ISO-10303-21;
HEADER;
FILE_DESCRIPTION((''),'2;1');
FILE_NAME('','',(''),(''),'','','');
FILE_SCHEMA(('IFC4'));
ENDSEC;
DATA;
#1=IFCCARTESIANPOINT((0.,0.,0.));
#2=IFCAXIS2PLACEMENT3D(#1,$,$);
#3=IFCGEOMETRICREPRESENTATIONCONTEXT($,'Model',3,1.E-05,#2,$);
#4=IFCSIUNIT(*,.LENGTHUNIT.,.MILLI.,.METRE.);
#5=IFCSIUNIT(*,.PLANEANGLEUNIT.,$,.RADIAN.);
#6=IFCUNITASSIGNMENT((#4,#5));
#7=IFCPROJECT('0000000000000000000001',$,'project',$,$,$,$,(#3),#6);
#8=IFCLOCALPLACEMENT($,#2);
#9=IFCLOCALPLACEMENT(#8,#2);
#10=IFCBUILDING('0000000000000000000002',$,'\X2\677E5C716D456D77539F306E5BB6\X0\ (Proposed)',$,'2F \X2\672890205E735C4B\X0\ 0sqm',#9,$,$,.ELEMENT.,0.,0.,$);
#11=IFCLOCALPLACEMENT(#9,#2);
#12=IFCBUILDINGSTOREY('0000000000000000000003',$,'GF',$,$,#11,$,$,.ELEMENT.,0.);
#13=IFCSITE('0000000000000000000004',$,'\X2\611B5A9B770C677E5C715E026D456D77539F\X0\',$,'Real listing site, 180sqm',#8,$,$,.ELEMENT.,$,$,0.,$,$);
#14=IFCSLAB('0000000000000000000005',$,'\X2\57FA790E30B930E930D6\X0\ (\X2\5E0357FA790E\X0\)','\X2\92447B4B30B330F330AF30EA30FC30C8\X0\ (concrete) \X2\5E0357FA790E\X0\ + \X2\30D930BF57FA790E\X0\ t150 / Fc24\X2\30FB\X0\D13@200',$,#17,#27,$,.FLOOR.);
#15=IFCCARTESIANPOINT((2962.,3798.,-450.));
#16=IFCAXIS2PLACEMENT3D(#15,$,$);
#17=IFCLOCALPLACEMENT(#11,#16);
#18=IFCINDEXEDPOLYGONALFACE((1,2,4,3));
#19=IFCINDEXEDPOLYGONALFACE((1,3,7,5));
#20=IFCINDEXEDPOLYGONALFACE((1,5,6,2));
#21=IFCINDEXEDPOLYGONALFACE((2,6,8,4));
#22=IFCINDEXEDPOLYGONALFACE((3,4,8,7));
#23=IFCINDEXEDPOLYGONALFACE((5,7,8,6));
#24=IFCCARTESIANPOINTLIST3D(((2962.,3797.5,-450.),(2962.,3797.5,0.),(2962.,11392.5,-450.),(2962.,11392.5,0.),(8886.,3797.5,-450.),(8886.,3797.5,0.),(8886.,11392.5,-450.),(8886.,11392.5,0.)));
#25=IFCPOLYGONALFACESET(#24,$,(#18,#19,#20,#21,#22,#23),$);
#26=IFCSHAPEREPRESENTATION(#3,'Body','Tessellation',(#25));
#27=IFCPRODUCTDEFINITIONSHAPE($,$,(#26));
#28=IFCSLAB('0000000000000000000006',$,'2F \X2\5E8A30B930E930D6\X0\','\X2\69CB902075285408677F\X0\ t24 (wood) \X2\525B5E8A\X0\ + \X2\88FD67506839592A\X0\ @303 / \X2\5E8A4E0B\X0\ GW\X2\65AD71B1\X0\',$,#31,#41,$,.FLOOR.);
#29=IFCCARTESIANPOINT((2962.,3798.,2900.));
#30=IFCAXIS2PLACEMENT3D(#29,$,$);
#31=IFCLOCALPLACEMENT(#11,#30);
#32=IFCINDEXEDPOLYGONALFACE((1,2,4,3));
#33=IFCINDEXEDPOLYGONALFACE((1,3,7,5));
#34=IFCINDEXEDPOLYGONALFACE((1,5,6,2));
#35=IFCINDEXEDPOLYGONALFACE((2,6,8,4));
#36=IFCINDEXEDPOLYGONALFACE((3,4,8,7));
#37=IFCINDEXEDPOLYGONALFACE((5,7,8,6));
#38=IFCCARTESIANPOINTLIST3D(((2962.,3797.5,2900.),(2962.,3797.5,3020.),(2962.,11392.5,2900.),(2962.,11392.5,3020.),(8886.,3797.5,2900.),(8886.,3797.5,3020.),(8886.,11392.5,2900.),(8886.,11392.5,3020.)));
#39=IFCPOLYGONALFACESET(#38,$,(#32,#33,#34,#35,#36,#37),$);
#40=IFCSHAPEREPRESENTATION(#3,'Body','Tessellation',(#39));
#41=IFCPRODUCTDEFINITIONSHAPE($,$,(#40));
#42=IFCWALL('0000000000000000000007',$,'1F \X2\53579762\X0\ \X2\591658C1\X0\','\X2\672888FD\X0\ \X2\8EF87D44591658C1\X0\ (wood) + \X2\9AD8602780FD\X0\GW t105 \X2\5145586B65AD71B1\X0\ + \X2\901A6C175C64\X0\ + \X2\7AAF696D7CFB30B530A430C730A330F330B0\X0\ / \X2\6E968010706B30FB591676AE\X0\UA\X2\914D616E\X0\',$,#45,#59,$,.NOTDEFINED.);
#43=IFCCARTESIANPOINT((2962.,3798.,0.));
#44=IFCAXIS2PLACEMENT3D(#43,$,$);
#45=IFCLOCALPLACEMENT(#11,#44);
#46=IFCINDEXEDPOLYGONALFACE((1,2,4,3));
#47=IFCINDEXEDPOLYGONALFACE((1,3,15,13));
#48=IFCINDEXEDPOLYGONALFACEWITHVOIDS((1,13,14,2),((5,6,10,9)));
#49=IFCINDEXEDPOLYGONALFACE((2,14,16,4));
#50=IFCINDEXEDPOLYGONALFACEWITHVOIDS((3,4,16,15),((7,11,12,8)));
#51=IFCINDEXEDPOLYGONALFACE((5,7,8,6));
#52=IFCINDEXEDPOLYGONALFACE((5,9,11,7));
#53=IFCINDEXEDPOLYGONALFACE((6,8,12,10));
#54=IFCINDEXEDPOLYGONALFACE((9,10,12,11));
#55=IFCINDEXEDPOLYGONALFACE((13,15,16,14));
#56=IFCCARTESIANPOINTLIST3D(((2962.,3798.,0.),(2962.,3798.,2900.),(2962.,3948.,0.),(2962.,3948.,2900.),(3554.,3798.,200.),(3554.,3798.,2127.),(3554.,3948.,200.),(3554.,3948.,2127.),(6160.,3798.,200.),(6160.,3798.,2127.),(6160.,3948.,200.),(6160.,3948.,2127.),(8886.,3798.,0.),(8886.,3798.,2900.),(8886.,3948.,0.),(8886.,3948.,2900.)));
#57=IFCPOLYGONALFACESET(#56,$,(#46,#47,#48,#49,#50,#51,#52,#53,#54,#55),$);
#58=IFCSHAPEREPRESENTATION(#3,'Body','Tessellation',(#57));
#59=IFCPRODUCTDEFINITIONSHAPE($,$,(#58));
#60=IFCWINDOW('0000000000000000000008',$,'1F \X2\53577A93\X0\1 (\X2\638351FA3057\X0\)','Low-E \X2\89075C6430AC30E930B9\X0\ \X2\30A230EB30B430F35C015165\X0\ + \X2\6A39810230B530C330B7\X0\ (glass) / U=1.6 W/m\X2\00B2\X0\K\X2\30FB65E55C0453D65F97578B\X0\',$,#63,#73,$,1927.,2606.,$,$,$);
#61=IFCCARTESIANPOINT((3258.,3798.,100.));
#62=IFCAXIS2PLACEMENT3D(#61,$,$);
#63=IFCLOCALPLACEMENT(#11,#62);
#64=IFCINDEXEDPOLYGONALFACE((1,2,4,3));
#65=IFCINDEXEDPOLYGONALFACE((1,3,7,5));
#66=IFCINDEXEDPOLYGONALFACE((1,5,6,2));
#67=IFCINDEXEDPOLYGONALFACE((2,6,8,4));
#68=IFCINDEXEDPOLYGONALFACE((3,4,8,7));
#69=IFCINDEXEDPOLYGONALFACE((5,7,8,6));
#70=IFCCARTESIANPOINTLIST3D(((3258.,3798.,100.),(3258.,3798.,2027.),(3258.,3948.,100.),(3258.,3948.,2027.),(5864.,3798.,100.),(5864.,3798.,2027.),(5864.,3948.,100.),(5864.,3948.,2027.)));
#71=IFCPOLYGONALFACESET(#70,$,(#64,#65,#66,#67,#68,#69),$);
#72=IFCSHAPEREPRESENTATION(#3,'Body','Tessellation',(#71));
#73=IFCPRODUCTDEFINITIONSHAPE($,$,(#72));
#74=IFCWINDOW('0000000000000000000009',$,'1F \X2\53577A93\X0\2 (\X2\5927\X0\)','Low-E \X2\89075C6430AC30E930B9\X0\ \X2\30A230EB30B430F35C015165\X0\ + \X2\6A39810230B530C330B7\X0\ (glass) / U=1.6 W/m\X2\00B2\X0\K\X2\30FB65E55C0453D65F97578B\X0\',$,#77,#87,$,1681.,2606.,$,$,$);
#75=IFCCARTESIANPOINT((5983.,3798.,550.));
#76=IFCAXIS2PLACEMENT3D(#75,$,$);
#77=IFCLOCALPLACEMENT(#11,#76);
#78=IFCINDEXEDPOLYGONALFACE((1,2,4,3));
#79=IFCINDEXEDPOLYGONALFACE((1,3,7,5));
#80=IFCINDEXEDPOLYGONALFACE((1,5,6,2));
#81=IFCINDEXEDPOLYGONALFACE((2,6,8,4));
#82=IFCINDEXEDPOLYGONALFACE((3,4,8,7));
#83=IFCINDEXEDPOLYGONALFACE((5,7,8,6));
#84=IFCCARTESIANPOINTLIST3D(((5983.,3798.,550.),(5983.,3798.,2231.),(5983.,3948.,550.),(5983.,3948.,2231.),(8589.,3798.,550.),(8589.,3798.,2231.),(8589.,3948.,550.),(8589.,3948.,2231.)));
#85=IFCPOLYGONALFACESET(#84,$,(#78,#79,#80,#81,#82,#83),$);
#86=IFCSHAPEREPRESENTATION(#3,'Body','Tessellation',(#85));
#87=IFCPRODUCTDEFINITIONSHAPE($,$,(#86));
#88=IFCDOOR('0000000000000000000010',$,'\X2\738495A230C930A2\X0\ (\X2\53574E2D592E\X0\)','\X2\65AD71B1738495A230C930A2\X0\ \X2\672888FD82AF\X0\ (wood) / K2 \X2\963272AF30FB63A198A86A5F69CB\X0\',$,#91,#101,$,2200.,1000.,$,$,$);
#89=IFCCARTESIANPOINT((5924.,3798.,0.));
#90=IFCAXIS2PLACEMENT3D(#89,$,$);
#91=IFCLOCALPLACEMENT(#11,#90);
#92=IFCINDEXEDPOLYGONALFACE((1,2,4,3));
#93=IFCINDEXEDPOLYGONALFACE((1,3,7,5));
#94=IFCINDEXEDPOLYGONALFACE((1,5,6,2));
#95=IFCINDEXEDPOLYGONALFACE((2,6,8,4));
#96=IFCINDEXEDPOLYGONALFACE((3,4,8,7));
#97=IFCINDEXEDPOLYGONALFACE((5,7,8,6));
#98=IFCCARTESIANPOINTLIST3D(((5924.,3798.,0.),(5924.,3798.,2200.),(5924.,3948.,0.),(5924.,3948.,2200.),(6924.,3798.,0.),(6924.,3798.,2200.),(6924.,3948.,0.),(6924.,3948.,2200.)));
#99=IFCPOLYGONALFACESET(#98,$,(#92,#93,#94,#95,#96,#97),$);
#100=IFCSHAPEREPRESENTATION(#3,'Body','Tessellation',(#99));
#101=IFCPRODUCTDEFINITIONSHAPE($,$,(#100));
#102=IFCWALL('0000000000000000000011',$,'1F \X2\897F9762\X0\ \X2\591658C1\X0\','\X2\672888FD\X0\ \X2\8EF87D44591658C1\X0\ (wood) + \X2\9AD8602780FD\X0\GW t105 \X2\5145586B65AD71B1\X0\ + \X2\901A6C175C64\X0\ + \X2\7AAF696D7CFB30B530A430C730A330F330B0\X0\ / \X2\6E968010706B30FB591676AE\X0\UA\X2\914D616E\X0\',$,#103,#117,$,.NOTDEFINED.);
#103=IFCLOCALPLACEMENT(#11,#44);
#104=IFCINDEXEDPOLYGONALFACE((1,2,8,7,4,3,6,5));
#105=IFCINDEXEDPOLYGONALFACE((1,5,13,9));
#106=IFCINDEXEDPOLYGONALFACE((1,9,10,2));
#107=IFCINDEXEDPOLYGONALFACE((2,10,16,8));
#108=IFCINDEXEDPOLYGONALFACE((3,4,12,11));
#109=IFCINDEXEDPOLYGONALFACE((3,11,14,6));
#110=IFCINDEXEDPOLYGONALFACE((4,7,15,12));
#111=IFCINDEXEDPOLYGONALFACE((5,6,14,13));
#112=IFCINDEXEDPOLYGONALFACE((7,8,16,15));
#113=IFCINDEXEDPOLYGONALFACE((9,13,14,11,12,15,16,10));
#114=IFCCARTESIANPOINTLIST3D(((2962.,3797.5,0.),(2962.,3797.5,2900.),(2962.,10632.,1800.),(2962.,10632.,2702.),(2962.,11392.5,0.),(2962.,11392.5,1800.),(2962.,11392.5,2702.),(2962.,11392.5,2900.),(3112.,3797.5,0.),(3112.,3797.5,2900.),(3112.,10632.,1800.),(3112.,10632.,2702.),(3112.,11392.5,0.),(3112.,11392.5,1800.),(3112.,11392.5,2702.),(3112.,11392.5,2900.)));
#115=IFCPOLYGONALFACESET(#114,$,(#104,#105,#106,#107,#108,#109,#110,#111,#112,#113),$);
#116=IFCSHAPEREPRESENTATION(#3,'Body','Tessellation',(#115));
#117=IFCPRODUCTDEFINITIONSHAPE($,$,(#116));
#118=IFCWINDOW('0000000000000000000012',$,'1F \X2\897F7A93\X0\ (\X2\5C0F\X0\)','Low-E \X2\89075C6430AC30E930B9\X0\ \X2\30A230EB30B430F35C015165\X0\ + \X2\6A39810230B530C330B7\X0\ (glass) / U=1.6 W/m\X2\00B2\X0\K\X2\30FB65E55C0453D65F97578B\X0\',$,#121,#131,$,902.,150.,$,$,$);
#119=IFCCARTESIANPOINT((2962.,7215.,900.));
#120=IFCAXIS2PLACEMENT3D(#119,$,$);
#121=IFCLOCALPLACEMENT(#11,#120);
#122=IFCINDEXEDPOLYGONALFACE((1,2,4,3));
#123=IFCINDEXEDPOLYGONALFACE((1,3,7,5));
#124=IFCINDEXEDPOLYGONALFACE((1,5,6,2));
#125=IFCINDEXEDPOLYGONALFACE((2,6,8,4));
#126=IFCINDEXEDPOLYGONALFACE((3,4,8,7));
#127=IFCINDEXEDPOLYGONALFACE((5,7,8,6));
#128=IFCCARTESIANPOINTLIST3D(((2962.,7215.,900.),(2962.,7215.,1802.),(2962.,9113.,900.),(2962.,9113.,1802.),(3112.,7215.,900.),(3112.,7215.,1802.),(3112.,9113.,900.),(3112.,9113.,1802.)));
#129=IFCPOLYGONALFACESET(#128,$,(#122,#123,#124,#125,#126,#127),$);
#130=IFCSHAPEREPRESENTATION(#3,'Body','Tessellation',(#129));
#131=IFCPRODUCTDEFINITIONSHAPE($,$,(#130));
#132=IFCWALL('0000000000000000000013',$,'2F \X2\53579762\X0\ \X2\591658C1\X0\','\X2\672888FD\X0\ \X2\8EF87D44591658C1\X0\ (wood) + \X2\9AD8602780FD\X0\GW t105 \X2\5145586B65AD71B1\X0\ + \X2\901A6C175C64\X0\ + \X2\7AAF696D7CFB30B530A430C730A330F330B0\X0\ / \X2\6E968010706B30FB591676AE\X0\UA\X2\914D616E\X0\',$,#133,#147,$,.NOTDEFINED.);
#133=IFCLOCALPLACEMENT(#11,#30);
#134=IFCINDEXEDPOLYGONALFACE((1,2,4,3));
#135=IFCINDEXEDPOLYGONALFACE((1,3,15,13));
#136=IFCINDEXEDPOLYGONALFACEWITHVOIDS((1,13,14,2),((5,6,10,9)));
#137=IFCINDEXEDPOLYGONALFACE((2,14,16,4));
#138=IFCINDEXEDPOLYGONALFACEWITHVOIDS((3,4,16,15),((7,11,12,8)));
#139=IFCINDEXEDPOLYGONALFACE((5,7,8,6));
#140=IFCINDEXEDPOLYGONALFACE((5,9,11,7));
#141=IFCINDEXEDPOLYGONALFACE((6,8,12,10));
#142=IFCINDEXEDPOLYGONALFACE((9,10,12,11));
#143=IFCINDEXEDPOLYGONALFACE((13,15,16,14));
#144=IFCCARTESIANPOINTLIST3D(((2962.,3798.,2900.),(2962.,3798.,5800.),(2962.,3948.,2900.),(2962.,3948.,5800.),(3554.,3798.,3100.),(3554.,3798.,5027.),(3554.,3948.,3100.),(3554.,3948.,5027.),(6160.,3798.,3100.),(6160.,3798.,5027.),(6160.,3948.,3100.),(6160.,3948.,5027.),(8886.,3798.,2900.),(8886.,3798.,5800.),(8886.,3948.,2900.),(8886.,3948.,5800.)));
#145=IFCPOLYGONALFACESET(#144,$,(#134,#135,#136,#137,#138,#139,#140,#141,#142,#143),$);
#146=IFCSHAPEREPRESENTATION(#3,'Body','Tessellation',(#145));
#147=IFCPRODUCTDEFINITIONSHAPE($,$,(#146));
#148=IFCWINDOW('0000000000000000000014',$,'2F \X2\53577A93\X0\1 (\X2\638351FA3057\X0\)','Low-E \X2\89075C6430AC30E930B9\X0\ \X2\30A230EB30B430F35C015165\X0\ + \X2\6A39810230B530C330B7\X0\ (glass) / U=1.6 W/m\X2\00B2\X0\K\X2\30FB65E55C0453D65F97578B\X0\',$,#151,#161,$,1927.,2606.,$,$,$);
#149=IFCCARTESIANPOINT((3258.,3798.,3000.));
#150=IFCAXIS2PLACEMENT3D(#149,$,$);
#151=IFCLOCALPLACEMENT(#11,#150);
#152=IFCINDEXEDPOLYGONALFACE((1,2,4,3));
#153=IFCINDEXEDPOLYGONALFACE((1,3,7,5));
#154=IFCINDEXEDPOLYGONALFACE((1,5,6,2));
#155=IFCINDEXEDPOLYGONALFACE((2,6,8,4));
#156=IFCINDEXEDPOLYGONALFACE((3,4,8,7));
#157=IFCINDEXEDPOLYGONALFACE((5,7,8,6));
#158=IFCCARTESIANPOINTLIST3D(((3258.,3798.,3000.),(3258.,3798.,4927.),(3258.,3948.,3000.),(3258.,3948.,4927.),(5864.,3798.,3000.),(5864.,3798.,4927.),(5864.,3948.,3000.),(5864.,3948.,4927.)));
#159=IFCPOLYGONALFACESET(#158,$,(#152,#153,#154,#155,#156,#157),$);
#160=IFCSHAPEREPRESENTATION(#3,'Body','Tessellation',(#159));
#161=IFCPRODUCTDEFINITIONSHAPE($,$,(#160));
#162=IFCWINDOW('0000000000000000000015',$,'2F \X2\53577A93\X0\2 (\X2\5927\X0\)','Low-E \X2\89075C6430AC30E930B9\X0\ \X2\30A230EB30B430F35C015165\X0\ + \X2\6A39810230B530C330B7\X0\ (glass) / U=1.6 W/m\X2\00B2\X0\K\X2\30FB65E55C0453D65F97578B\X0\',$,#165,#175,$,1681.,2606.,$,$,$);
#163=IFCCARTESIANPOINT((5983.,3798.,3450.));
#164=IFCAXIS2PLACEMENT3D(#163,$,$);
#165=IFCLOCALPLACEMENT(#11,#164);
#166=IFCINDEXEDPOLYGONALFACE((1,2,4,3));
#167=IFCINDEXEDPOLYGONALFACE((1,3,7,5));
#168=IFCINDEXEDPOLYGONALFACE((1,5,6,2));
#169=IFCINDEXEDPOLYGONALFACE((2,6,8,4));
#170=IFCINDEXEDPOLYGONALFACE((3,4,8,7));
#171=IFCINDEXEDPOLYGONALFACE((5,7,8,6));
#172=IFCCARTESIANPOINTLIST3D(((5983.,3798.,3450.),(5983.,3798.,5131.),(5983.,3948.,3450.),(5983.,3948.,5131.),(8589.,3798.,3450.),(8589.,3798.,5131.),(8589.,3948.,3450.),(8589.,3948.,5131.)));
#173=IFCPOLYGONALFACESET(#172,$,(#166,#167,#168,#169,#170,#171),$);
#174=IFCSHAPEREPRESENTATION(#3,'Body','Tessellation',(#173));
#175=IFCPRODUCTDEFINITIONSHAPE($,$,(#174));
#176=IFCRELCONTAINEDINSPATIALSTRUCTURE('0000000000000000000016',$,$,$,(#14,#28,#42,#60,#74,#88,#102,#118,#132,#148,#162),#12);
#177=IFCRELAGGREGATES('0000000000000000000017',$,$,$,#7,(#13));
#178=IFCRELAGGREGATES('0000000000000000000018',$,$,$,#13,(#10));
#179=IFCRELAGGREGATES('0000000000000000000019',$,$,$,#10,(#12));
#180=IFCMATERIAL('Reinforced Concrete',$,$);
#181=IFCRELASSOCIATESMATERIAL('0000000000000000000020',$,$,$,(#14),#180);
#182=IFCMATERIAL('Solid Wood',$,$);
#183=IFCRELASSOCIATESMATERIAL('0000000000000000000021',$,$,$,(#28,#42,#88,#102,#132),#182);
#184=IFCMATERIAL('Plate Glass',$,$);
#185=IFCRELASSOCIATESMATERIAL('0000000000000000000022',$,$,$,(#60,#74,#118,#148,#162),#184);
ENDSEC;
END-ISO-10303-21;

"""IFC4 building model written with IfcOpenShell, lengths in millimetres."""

from ifc_helpers import new_model, si_unit, frame, frame_2d, origin, place, context, project, spatial, rectangle, extrude, material, element, fill, save


model = new_model("IFC4")

# Units and contexts
model_context = context("Model", 3, precision=1e-05, world=origin())
ifc_project = project(units=[si_unit("LENGTHUNIT", "METRE", prefix="MILLI"), si_unit("PLANEANGLEUNIT", "RADIAN")], contexts=[model_context])

# Site, building, storey
site_placement = place(None, origin())
site = spatial("IfcSite", under=ifc_project, at=site_placement, Name="愛媛県松山市浅海原", ObjectType="Real listing site, 180sqm", CompositionType="ELEMENT", RefElevation=0.0)
building_placement = place(site_placement, origin())
building = spatial("IfcBuilding", under=site, at=building_placement, Name="松山浅海原の家 (Proposed)", ObjectType="2F 木造平屋 0sqm", CompositionType="ELEMENT", ElevationOfRefHeight=0.0, ElevationOfTerrain=0.0)
storey_placement = place(building_placement, origin())
storey = spatial("IfcBuildingStorey", under=building, at=storey_placement, Name="GF", CompositionType="ELEMENT", Elevation=0.0)

# Slabs
ifc_material_1 = material(Name="Reinforced Concrete")
slab_1_placement = place(storey_placement, frame((2962.0, 3798.0, -450.0)))
element("IfcSlab", 1, at=slab_1_placement, inside=storey, material=ifc_material_1, Name="基礎スラブ (布基礎)", Description="鉄筋コンクリート (concrete) 布基礎 + ベタ基礎 t150 / Fc24・D13@200", PredefinedType="FLOOR", context=model_context, shape_type="SweptSolid", body=[
    extrude(rectangle(XDim=5924.0, YDim=7595.0, at=frame_2d((2962.0, 3797.0))), frame((2962.0, 3798.0, -450.0)), (0.0, 0.0, 1.0), 450.0),
])
ifc_material_2 = material(Name="Solid Wood")
slab_2_placement = place(storey_placement, frame((2962.0, 3798.0, 2900.0)))
element("IfcSlab", 2, at=slab_2_placement, inside=storey, material=ifc_material_2, Name="2F 床スラブ", Description="構造用合板 t24 (wood) 剛床 + 製材根太 @303 / 床下 GW断熱", PredefinedType="FLOOR", context=model_context, shape_type="SweptSolid", body=[
    extrude(rectangle(XDim=5924.0, YDim=7595.0, at=frame_2d((2962.0, 3797.0))), frame((2962.0, 3798.0, 2900.0)), (0.0, 0.0, 1.0), 120.0),
])

# Wall, openings, windows, door
wall_1_placement = place(storey_placement, frame((2962.0, 3798.0, 0.0)))
wall_1 = element("IfcWall", 3, at=wall_1_placement, inside=storey, material=ifc_material_2, Name="1F 南面 外壁", Description="木製 軸組外壁 (wood) + 高性能GW t105 充填断熱 + 通気層 + 窯業系サイディング / 準耐火・外皮UA配慮", PredefinedType="NOTDEFINED", context=model_context, shape_type="SweptSolid", body=[
    extrude(rectangle(XDim=5924.0, YDim=150.0, at=frame_2d((2962.0, 75.0))), frame((2962.0, 3798.0, 0.0)), (0.0, 0.0, 1.0), 2900.0),
])
opening_1_placement = place(storey_placement, frame((3258.0, 3798.0, 100.0)))
opening_1 = element("IfcOpeningElement", 4, at=opening_1_placement, cuts=wall_1, PredefinedType="NOTDEFINED", context=model_context, shape_type="SweptSolid", body=[
    extrude(rectangle(XDim=2606.0, YDim=150.0, at=frame_2d((1303.0, 75.0))), frame((3258.0, 3798.0, 100.0)), (0.0, 0.0, 1.0), 1927.0),
])
opening_2_placement = place(storey_placement, frame((5983.0, 3798.0, 550.0)))
opening_2 = element("IfcOpeningElement", 5, at=opening_2_placement, cuts=wall_1, PredefinedType="NOTDEFINED", context=model_context, shape_type="SweptSolid", body=[
    extrude(rectangle(XDim=2606.0, YDim=150.0, at=frame_2d((1303.0, 75.0))), frame((5983.0, 3798.0, 550.0)), (0.0, 0.0, 1.0), 1681.0),
])
opening_3_placement = place(storey_placement, frame((5924.0, 3798.0, 0.0)))
opening_3 = element("IfcOpeningElement", 6, at=opening_3_placement, cuts=wall_1, PredefinedType="NOTDEFINED", context=model_context, shape_type="SweptSolid", body=[
    extrude(rectangle(XDim=1000.0, YDim=150.0, at=frame_2d((500.0, 75.0))), frame((5924.0, 3798.0, 0.0)), (0.0, 0.0, 1.0), 2200.0),
])
ifc_material_3 = material(Name="Plate Glass")
window_1_placement = place(storey_placement, frame((3258.0, 3798.0, 100.0)))
window_1 = element("IfcWindow", 7, at=window_1_placement, inside=storey, material=ifc_material_3, Name="1F 南窓1 (掃出し)", Description="Low-E 複層ガラス アルゴン封入 + 樹脂サッシ (glass) / U=1.6 W/m²K・日射取得型", OverallHeight=1927.0, OverallWidth=2606.0, context=model_context, shape_type="SweptSolid", body=[
    extrude(rectangle(XDim=2606.0, YDim=150.0, at=frame_2d((1303.0, 75.0))), frame((3258.0, 3798.0, 100.0)), (0.0, 0.0, 1.0), 1927.0),
])
fill(opening_1, window_1)
window_2_placement = place(storey_placement, frame((5983.0, 3798.0, 550.0)))
window_2 = element("IfcWindow", 8, at=window_2_placement, inside=storey, material=ifc_material_3, Name="1F 南窓2 (大)", Description="Low-E 複層ガラス アルゴン封入 + 樹脂サッシ (glass) / U=1.6 W/m²K・日射取得型", OverallHeight=1681.0, OverallWidth=2606.0, context=model_context, shape_type="SweptSolid", body=[
    extrude(rectangle(XDim=2606.0, YDim=150.0, at=frame_2d((1303.0, 75.0))), frame((5983.0, 3798.0, 550.0)), (0.0, 0.0, 1.0), 1681.0),
])
fill(opening_2, window_2)
door_placement = place(storey_placement, frame((5924.0, 3798.0, 0.0)))
door = element("IfcDoor", 9, at=door_placement, inside=storey, material=ifc_material_2, Name="玄関ドア (南中央)", Description="断熱玄関ドア 木製芯 (wood) / K2 防犯・採風機構", OverallHeight=2200.0, OverallWidth=1000.0, context=model_context, shape_type="SweptSolid", body=[
    extrude(rectangle(XDim=1000.0, YDim=150.0, at=frame_2d((500.0, 75.0))), frame((5924.0, 3798.0, 0.0)), (0.0, 0.0, 1.0), 2200.0),
])
fill(opening_3, door)

# Wall, opening, window
wall_2_placement = place(storey_placement, frame((2962.0, 3798.0, 0.0)))
wall_2 = element("IfcWall", 10, at=wall_2_placement, inside=storey, material=ifc_material_2, Name="1F 西面 外壁", Description="木製 軸組外壁 (wood) + 高性能GW t105 充填断熱 + 通気層 + 窯業系サイディング / 準耐火・外皮UA配慮", PredefinedType="NOTDEFINED", context=model_context, shape_type="SweptSolid", body=[
    extrude(rectangle(XDim=150.0, YDim=7595.0, at=frame_2d((75.0, 3797.0))), frame((2962.0, 3798.0, 0.0)), (0.0, 0.0, 1.0), 2900.0),
])
opening_4_placement = place(storey_placement, frame((2962.0, 7215.0, 900.0)))
opening_4 = element("IfcOpeningElement", 11, at=opening_4_placement, cuts=wall_2, PredefinedType="NOTDEFINED", context=model_context, shape_type="SweptSolid", body=[
    extrude(rectangle(XDim=150.0, YDim=1898.0, at=frame_2d((75.0, 949.0))), frame((2962.0, 7215.0, 900.0)), (0.0, 0.0, 1.0), 902.0),
])
window_3_placement = place(storey_placement, frame((2962.0, 7215.0, 900.0)))
window_3 = element("IfcWindow", 12, at=window_3_placement, inside=storey, material=ifc_material_3, Name="1F 西窓 (小)", Description="Low-E 複層ガラス アルゴン封入 + 樹脂サッシ (glass) / U=1.6 W/m²K・日射取得型", OverallHeight=902.0, OverallWidth=150.0, context=model_context, shape_type="SweptSolid", body=[
    extrude(rectangle(XDim=150.0, YDim=1898.0, at=frame_2d((75.0, 949.0))), frame((2962.0, 7215.0, 900.0)), (0.0, 0.0, 1.0), 902.0),
])
fill(opening_4, window_3)

# Wall, openings, windows
wall_3_placement = place(storey_placement, frame((2962.0, 3798.0, 2900.0)))
wall_3 = element("IfcWall", 13, at=wall_3_placement, inside=storey, material=ifc_material_2, Name="2F 南面 外壁", Description="木製 軸組外壁 (wood) + 高性能GW t105 充填断熱 + 通気層 + 窯業系サイディング / 準耐火・外皮UA配慮", PredefinedType="NOTDEFINED", context=model_context, shape_type="SweptSolid", body=[
    extrude(rectangle(XDim=5924.0, YDim=150.0, at=frame_2d((2962.0, 75.0))), frame((2962.0, 3798.0, 2900.0)), (0.0, 0.0, 1.0), 2900.0),
])
opening_5_placement = place(storey_placement, frame((3258.0, 3798.0, 3000.0)))
opening_5 = element("IfcOpeningElement", 14, at=opening_5_placement, cuts=wall_3, PredefinedType="NOTDEFINED", context=model_context, shape_type="SweptSolid", body=[
    extrude(rectangle(XDim=2606.0, YDim=150.0, at=frame_2d((1303.0, 75.0))), frame((3258.0, 3798.0, 3000.0)), (0.0, 0.0, 1.0), 1927.0),
])
opening_6_placement = place(storey_placement, frame((5983.0, 3798.0, 3450.0)))
opening_6 = element("IfcOpeningElement", 15, at=opening_6_placement, cuts=wall_3, PredefinedType="NOTDEFINED", context=model_context, shape_type="SweptSolid", body=[
    extrude(rectangle(XDim=2606.0, YDim=150.0, at=frame_2d((1303.0, 75.0))), frame((5983.0, 3798.0, 3450.0)), (0.0, 0.0, 1.0), 1681.0),
])
window_4_placement = place(storey_placement, frame((3258.0, 3798.0, 3000.0)))
window_4 = element("IfcWindow", 16, at=window_4_placement, inside=storey, material=ifc_material_3, Name="2F 南窓1 (掃出し)", Description="Low-E 複層ガラス アルゴン封入 + 樹脂サッシ (glass) / U=1.6 W/m²K・日射取得型", OverallHeight=1927.0, OverallWidth=2606.0, context=model_context, shape_type="SweptSolid", body=[
    extrude(rectangle(XDim=2606.0, YDim=150.0, at=frame_2d((1303.0, 75.0))), frame((3258.0, 3798.0, 3000.0)), (0.0, 0.0, 1.0), 1927.0),
])
fill(opening_5, window_4)
window_5_placement = place(storey_placement, frame((5983.0, 3798.0, 3450.0)))
window_5 = element("IfcWindow", 17, at=window_5_placement, inside=storey, material=ifc_material_3, Name="2F 南窓2 (大)", Description="Low-E 複層ガラス アルゴン封入 + 樹脂サッシ (glass) / U=1.6 W/m²K・日射取得型", OverallHeight=1681.0, OverallWidth=2606.0, context=model_context, shape_type="SweptSolid", body=[
    extrude(rectangle(XDim=2606.0, YDim=150.0, at=frame_2d((1303.0, 75.0))), frame((5983.0, 3798.0, 3450.0)), (0.0, 0.0, 1.0), 1681.0),
])
fill(opening_6, window_5)

save(model, "model.ifc")
